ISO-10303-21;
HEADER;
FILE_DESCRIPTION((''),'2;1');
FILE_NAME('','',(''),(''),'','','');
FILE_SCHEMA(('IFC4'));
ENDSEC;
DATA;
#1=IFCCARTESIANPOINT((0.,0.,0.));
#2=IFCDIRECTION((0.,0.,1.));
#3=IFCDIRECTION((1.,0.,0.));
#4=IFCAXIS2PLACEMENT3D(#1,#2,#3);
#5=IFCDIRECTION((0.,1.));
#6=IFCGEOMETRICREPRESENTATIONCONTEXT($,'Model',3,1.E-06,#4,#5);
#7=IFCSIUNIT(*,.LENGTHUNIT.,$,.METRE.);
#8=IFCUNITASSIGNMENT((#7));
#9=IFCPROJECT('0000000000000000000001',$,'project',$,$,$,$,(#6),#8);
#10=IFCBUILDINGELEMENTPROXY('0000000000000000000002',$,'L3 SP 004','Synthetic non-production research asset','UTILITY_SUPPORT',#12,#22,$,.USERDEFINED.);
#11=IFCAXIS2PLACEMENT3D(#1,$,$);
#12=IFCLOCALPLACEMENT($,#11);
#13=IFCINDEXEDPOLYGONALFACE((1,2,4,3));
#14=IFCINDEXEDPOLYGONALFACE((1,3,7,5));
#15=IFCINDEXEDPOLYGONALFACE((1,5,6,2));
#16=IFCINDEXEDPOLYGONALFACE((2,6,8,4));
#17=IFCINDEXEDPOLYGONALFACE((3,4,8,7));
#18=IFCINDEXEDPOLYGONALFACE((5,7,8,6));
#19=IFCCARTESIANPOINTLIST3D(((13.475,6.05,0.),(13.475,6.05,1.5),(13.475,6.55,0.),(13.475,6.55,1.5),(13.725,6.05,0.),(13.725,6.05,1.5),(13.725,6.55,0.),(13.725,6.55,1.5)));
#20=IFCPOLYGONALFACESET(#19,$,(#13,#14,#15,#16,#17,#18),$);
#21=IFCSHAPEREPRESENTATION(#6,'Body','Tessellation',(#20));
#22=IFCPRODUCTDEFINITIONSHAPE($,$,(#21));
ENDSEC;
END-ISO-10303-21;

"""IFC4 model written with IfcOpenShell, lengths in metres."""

from ifc_helpers import new_model, si_unit, direction, frame, origin_with_axes, origin_2d_with_axis, place, context, project, rectangle, extrude, element, save


model = new_model("IFC4")

# Units and contexts
model_context = context("Model", 3, precision=1e-06, world=origin_with_axes(), true_north=direction((0.0, 1.0)))
ifc_project = project(units=[si_unit("LENGTHUNIT", "METRE")], contexts=[model_context])

# Building element proxy
proxy_placement = place(None, frame((13.6, 6.3, 0.0), z_axis=(0.0, 0.0, 1.0), x_axis=(1.0, 0.0, 0.0)))
element("IfcBuildingElementProxy", 1, at=proxy_placement, Name="L3 SP 004", Description="Synthetic non-production research asset", ObjectType="UTILITY_SUPPORT", PredefinedType="USERDEFINED", context=model_context, shape_type="SweptSolid", body=[
    extrude(rectangle(XDim=0.25, YDim=0.5, at=origin_2d_with_axis()), origin_with_axes(), (0.0, 0.0, 1.0), 1.5),
])

save(model, "model.ifc")
